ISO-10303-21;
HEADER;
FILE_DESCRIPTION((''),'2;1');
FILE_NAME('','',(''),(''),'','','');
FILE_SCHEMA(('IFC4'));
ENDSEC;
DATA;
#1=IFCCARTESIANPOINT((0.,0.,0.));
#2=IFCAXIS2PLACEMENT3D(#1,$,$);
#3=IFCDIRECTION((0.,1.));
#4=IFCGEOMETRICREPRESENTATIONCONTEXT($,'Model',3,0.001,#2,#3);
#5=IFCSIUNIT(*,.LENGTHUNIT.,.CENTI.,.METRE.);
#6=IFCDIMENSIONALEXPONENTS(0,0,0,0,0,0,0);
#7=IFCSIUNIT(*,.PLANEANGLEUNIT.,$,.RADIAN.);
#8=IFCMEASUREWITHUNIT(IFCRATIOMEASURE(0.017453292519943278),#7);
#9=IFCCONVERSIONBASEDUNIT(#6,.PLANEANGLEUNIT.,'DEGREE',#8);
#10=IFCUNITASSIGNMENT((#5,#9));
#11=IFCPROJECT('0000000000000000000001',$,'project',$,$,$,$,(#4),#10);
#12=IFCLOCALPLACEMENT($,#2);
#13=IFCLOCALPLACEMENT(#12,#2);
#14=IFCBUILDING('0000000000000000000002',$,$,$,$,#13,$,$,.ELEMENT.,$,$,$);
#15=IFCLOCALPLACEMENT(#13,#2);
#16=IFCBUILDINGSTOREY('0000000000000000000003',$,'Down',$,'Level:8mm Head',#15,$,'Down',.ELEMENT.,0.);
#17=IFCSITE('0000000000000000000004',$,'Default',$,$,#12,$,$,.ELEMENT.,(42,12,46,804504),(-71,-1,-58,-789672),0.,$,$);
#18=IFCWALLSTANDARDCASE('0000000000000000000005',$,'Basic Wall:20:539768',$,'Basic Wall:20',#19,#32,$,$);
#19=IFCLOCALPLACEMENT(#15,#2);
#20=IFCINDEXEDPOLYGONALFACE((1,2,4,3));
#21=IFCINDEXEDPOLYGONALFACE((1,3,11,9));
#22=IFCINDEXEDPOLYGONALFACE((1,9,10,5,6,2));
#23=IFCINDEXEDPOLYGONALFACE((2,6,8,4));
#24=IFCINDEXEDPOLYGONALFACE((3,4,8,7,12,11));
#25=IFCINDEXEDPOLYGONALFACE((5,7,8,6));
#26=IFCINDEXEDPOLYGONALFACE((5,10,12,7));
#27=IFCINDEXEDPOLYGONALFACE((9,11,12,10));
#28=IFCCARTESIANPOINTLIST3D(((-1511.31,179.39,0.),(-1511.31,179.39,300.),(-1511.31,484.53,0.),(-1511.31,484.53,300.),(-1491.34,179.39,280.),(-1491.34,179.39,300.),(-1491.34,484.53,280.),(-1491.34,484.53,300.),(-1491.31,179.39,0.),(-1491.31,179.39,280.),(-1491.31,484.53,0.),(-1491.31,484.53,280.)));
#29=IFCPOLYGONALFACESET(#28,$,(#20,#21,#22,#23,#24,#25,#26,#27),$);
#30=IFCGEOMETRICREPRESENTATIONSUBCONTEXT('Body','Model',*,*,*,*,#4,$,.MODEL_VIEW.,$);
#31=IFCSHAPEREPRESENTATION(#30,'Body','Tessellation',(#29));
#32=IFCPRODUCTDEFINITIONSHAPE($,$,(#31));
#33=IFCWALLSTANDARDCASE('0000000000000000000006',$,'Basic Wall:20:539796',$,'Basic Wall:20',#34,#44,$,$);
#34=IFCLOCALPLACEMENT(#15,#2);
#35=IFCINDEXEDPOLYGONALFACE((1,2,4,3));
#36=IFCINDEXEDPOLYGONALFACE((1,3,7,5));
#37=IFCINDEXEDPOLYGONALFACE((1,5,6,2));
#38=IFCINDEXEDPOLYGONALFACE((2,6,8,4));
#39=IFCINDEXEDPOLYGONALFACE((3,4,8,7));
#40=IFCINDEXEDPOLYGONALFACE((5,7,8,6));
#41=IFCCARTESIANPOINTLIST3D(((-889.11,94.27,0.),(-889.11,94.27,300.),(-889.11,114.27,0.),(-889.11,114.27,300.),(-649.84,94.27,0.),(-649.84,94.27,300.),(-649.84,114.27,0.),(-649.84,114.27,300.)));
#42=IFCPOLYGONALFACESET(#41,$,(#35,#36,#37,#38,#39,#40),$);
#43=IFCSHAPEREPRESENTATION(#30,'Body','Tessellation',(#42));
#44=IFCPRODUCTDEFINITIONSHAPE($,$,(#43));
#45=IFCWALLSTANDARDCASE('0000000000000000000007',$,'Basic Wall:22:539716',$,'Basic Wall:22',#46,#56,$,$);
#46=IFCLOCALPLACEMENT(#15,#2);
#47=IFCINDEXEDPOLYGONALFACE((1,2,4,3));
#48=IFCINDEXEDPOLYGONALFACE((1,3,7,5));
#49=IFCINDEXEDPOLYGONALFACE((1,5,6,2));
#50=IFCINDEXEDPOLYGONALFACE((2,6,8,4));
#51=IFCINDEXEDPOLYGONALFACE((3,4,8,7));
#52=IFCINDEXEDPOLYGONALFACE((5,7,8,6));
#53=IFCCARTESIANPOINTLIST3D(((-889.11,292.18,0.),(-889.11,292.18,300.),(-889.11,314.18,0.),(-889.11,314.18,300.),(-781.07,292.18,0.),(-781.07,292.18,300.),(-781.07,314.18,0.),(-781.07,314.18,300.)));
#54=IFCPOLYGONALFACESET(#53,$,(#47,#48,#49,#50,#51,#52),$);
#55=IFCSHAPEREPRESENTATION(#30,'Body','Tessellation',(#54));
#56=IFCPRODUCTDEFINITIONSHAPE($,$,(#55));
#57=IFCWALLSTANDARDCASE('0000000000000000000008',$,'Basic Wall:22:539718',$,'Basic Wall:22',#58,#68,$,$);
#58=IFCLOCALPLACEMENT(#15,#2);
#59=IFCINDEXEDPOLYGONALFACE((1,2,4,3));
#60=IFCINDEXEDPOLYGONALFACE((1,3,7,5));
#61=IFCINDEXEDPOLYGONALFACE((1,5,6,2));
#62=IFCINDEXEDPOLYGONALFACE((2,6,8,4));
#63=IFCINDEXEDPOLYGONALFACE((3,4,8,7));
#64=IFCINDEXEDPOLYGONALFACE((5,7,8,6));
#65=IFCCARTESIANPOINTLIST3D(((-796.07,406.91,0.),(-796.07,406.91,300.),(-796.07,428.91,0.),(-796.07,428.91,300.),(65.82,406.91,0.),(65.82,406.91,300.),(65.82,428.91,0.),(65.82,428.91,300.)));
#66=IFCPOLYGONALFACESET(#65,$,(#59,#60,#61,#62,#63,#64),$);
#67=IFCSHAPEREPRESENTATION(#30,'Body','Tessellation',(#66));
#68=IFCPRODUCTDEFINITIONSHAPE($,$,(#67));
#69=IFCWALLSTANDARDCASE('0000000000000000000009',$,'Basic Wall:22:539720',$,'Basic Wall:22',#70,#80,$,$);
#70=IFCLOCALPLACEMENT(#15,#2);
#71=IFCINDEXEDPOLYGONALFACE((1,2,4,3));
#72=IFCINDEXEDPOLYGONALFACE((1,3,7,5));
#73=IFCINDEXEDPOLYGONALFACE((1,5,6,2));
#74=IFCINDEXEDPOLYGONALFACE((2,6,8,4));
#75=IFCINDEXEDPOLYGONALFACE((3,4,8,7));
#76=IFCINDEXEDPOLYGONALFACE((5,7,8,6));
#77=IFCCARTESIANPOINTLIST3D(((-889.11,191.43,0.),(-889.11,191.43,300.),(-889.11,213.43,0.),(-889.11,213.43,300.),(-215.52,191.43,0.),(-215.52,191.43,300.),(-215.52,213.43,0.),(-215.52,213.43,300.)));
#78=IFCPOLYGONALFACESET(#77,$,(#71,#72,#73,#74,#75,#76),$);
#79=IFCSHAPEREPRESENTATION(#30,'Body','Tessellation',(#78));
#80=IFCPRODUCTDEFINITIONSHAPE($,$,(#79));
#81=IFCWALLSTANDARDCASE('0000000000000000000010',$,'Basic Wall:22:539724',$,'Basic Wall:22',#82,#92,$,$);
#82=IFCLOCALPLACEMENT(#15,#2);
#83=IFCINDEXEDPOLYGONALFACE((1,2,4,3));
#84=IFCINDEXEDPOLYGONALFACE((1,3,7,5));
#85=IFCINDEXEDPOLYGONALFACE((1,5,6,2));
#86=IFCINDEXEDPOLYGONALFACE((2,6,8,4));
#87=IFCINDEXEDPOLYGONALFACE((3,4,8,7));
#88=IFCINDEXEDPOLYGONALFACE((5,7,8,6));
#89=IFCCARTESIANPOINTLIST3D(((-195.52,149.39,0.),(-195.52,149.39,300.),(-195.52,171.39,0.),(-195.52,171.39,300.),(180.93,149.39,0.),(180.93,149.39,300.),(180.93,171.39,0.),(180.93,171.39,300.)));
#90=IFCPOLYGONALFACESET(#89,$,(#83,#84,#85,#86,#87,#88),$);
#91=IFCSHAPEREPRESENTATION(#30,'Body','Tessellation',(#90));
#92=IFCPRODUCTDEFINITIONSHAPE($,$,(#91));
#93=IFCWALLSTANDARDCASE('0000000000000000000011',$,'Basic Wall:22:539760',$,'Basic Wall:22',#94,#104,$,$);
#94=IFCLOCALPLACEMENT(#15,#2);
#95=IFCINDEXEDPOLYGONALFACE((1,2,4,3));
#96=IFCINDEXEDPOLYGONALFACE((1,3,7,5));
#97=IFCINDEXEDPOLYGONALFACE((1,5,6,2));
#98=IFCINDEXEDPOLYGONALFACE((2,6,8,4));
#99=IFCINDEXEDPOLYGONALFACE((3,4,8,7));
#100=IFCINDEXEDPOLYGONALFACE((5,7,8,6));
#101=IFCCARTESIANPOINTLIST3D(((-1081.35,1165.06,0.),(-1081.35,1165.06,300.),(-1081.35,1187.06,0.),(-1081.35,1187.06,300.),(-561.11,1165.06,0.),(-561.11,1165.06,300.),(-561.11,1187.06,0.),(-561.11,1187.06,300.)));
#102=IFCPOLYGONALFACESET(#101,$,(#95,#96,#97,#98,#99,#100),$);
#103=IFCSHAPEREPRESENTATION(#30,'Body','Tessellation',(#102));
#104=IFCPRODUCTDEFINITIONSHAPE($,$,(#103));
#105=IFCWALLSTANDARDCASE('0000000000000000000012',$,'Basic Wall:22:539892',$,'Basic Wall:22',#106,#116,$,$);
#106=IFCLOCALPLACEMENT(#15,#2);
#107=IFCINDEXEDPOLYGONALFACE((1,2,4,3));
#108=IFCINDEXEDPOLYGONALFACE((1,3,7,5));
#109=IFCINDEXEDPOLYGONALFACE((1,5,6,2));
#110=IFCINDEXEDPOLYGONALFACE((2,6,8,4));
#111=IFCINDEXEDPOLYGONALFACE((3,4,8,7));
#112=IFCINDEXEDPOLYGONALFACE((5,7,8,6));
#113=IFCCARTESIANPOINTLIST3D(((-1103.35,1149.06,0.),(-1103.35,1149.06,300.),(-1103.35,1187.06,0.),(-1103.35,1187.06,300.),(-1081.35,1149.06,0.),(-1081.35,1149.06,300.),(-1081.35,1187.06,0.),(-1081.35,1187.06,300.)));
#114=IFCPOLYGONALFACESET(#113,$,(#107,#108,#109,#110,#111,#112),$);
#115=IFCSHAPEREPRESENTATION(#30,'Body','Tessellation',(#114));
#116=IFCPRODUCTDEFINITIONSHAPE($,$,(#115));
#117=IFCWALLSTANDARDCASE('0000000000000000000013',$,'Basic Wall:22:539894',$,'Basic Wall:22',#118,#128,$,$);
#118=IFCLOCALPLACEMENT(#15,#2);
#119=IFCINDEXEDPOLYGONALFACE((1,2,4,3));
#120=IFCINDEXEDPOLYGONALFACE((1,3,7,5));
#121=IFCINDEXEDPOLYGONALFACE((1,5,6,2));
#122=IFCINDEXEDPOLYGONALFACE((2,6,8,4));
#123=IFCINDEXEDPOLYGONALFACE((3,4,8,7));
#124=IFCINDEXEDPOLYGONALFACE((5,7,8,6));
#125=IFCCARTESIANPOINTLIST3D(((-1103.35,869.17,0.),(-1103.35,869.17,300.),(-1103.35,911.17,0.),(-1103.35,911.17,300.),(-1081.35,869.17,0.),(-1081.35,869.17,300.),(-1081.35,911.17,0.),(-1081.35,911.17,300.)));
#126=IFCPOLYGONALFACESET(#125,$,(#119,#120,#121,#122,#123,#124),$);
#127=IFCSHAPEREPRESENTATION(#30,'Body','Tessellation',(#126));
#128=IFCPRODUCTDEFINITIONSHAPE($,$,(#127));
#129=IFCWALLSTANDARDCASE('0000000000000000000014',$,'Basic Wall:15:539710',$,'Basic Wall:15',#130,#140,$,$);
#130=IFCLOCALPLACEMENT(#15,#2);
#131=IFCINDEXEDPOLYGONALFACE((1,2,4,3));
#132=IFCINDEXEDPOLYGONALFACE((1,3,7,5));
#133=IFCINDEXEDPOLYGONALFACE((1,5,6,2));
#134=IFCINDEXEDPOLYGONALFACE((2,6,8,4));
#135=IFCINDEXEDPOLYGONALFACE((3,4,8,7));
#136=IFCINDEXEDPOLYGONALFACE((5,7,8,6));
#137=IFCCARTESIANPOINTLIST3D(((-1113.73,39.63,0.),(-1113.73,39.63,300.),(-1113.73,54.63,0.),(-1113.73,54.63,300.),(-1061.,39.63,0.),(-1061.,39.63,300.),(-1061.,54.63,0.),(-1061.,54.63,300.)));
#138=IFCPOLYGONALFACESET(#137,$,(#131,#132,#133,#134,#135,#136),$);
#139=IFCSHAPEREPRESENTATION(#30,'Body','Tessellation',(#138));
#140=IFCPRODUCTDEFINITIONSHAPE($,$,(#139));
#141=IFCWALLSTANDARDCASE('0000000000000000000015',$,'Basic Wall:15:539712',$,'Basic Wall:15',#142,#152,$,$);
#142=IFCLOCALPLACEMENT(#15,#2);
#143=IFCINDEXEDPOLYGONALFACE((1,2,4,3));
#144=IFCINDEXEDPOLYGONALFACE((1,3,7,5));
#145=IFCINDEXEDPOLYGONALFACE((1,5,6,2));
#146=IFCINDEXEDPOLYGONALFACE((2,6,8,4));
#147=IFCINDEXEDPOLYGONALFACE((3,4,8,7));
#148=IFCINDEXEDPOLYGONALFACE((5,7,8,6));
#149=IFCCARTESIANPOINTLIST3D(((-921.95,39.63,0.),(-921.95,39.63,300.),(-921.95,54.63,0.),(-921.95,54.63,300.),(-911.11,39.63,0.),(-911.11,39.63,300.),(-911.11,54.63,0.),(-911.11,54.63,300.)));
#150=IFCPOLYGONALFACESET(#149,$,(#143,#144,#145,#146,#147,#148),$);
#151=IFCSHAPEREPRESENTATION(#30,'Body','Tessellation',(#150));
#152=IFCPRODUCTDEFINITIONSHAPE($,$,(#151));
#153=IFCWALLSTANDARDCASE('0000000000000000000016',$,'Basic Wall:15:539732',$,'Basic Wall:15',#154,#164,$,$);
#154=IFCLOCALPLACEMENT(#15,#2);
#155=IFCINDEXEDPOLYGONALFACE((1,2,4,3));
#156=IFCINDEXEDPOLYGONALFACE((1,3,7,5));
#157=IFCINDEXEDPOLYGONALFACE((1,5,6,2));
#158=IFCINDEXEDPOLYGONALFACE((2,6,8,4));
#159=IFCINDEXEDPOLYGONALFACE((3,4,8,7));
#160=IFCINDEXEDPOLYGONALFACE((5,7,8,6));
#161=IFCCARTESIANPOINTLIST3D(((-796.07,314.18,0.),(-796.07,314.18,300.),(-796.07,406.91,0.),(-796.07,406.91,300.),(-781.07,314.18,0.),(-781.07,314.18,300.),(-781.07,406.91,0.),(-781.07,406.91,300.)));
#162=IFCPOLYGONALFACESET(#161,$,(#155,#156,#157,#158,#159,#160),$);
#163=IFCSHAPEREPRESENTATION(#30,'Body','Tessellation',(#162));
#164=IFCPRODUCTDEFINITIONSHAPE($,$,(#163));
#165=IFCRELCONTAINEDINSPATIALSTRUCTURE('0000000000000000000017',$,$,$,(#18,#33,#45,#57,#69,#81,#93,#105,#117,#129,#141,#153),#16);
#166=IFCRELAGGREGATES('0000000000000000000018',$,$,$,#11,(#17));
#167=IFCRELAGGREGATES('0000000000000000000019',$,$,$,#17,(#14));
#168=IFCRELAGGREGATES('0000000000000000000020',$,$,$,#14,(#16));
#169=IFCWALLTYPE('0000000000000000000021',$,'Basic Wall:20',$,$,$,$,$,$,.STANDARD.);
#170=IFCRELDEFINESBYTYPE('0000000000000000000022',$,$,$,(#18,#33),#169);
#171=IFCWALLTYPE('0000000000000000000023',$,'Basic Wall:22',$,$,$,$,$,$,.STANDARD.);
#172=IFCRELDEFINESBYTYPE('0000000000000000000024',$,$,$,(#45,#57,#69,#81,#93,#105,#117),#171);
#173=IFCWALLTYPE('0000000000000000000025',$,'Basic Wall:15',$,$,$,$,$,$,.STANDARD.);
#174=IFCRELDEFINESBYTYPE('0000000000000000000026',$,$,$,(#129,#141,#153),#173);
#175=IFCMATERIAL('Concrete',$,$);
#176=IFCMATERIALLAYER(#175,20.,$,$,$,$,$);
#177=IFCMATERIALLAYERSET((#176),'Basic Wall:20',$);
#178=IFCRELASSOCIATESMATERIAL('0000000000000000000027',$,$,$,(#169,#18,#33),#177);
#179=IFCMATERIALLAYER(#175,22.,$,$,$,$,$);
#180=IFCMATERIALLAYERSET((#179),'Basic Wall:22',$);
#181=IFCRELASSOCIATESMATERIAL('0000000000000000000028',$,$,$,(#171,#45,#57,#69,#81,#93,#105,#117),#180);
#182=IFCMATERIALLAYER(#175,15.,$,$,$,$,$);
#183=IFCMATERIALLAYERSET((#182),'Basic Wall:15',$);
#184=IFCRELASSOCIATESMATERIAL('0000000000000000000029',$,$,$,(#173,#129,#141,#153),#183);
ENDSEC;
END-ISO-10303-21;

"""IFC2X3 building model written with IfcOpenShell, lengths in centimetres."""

from ifc_helpers import new_model, entity, si_unit, converted_unit, direction, frame, frame_2d, origin, place, context, subcontext, project, spatial, polyline, rectangle, extrude, clip, bounded_halfspace, material, layer, layer_set, layer_usage, type_object, element, save


model = new_model("IFC2X3")

# Units and contexts
model_context = context("Model", 3, precision=0.001, world=origin(), true_north=direction((0.0, 1.0)))
body_context = subcontext(model_context, "Body", "Model", "MODEL_VIEW")
ifc_project = project(units=[si_unit("LENGTHUNIT", "METRE", prefix="CENTI"), converted_unit("PLANEANGLEUNIT", "DEGREE", entity("IfcRatioMeasure", 0.017453292519943278), si_unit("PLANEANGLEUNIT", "RADIAN"), dimensions=[0, 0, 0, 0, 0, 0, 0])], contexts=[model_context])

# Site, building, storey
site_placement = place(None, origin())
site = spatial("IfcSite", under=ifc_project, at=site_placement, Name="Default", CompositionType="ELEMENT", RefLatitude=(42, 12, 46, 804504), RefLongitude=(-71, -1, -58, -789672), RefElevation=0.0)
building_placement = place(site_placement, origin())
building = spatial("IfcBuilding", under=site, at=building_placement, CompositionType="ELEMENT")
storey_placement = place(building_placement, origin())
storey = spatial("IfcBuildingStorey", under=building, at=storey_placement, Name="Down", ObjectType="Level:8mm Head", LongName="Down", CompositionType="ELEMENT", Elevation=0.0)

# Walls
ifc_material = material(Name="Concrete")
ifc_layer_1 = layer(ifc_material, 20.0)
ifc_layer_set_1 = layer_set([ifc_layer_1], Name="Basic Wall:20")
wall_type_1 = type_object("IfcWallType", Name="Basic Wall:20", PredefinedType="STANDARD", material=ifc_layer_set_1)
ifc_layer_usage_1 = layer_usage(ifc_layer_set_1, "AXIS2", "POSITIVE", -10.0)
wall_1_placement = place(storey_placement, frame((-1501.31, 484.53, 0.0), z_axis=(0.0, 0.0, 1.0), x_axis=(0.0, -1.0, 0.0)))
element("IfcWallStandardCase", 1, at=wall_1_placement, inside=storey, type_object=wall_type_1, material=ifc_layer_usage_1, Name="Basic Wall:20:539768", ObjectType="Basic Wall:20", context=body_context, shape_type="Clipping", body=[
    clip(clip(extrude(rectangle(XDim=305.14, YDim=20.0, at=frame_2d((152.57, 0.0), x_axis=(-1.0, 0.0))), origin(), (0.0, 0.0, 1.0), 300.0), bounded_halfspace(frame((0.0, 9.97, 280.0), z_axis=(0.0, 0.0, -1.0), x_axis=(-1.0, 0.0, 0.0)), True, frame((0.0, 9.97, 280.0), z_axis=(0.0, 0.0, -1.0), x_axis=(-1.0, 0.0, 0.0)), polyline([(0.0, 0.0), (0.0, 0.03), (-305.14, 0.03), (-305.14, 0.0), (0.0, 0.0)]))), bounded_halfspace(frame((305.14, 9.97, 280.0), z_axis=(0.0, -1.0, 0.0), x_axis=(0.0, 0.0, 1.0)), True, frame((305.14, 9.97, 280.0), z_axis=(0.0, -1.0, 0.0), x_axis=(0.0, 0.0, 1.0)), polyline([(0.0, 0.0), (20.0, 0.0), (20.0, 305.14), (0.0, 305.14), (0.0, 0.0)]))),
])
ifc_layer_usage_2 = layer_usage(ifc_layer_set_1, "AXIS2", "NEGATIVE", 10.0)
wall_2_placement = place(storey_placement, frame((-889.11, 104.27, 0.0)))
element("IfcWallStandardCase", 2, at=wall_2_placement, inside=storey, type_object=wall_type_1, material=ifc_layer_usage_2, Name="Basic Wall:20:539796", ObjectType="Basic Wall:20", context=body_context, shape_type="SweptSolid", body=[
    extrude(rectangle(XDim=239.27, YDim=20.0, at=frame_2d((119.63, 0.0), x_axis=(-1.0, 0.0))), origin(), (0.0, 0.0, 1.0), 300.0),
])
ifc_layer_2 = layer(ifc_material, 22.0)
ifc_layer_set_2 = layer_set([ifc_layer_2], Name="Basic Wall:22")
ifc_layer_usage_3 = layer_usage(ifc_layer_set_2, "AXIS2", "NEGATIVE", 11.0)
wall_type_2 = type_object("IfcWallType", Name="Basic Wall:22", PredefinedType="STANDARD", material=ifc_layer_set_2)
wall_3_placement = place(storey_placement, frame((-889.11, 303.18, 0.0)))
element("IfcWallStandardCase", 3, at=wall_3_placement, inside=storey, type_object=wall_type_2, material=ifc_layer_usage_3, Name="Basic Wall:22:539716", ObjectType="Basic Wall:22", context=body_context, shape_type="SweptSolid", body=[
    extrude(rectangle(XDim=108.04, YDim=22.0, at=frame_2d((54.02, 0.0), x_axis=(-1.0, 0.0))), origin(), (0.0, 0.0, 1.0), 300.0),
])
ifc_layer_usage_4 = layer_usage(ifc_layer_set_2, "AXIS2", "POSITIVE", -11.0)
wall_4_placement = place(storey_placement, frame((-796.07, 417.91, 0.0)))
element("IfcWallStandardCase", 4, at=wall_4_placement, inside=storey, type_object=wall_type_2, material=ifc_layer_usage_4, Name="Basic Wall:22:539718", ObjectType="Basic Wall:22", context=body_context, shape_type="SweptSolid", body=[
    extrude(rectangle(XDim=861.89, YDim=22.0, at=frame_2d((430.94, 0.0), x_axis=(-1.0, 0.0))), origin(), (0.0, 0.0, 1.0), 300.0),
])
ifc_layer_usage_5 = layer_usage(ifc_layer_set_2, "AXIS2", "NEGATIVE", 11.0)
wall_5_placement = place(storey_placement, frame((-889.11, 202.43, 0.0)))
element("IfcWallStandardCase", 5, at=wall_5_placement, inside=storey, type_object=wall_type_2, material=ifc_layer_usage_5, Name="Basic Wall:22:539720", ObjectType="Basic Wall:22", context=body_context, shape_type="SweptSolid", body=[
    extrude(rectangle(XDim=673.59, YDim=22.0, at=frame_2d((336.79, 0.0), x_axis=(-1.0, 0.0))), origin(), (0.0, 0.0, 1.0), 300.0),
])
ifc_layer_usage_6 = layer_usage(ifc_layer_set_2, "AXIS2", "NEGATIVE", 11.0)
wall_6_placement = place(storey_placement, frame((-195.52, 160.39, 0.0)))
element("IfcWallStandardCase", 6, at=wall_6_placement, inside=storey, type_object=wall_type_2, material=ifc_layer_usage_6, Name="Basic Wall:22:539724", ObjectType="Basic Wall:22", context=body_context, shape_type="SweptSolid", body=[
    extrude(rectangle(XDim=376.45, YDim=22.0, at=frame_2d((188.23, 0.0), x_axis=(-1.0, 0.0))), origin(), (0.0, 0.0, 1.0), 300.0),
])
ifc_layer_usage_7 = layer_usage(ifc_layer_set_2, "AXIS2", "NEGATIVE", 11.0)
wall_7_placement = place(storey_placement, frame((-561.11, 1176.06, 0.0), z_axis=(0.0, 0.0, 1.0), x_axis=(-1.0, 0.0, 0.0)))
element("IfcWallStandardCase", 7, at=wall_7_placement, inside=storey, type_object=wall_type_2, material=ifc_layer_usage_7, Name="Basic Wall:22:539760", ObjectType="Basic Wall:22", context=body_context, shape_type="SweptSolid", body=[
    extrude(rectangle(XDim=520.24, YDim=22.0, at=frame_2d((260.12, 0.0), x_axis=(-1.0, 0.0))), origin(), (0.0, 0.0, 1.0), 300.0),
])
ifc_layer_usage_8 = layer_usage(ifc_layer_set_2, "AXIS2", "POSITIVE", -11.0)
wall_8_placement = place(storey_placement, frame((-1092.35, 1187.06, 0.0), z_axis=(0.0, 0.0, 1.0), x_axis=(0.0, -1.0, 0.0)))
element("IfcWallStandardCase", 8, at=wall_8_placement, inside=storey, type_object=wall_type_2, material=ifc_layer_usage_8, Name="Basic Wall:22:539892", ObjectType="Basic Wall:22", context=body_context, shape_type="SweptSolid", body=[
    extrude(rectangle(XDim=38.0, YDim=22.0, at=frame_2d((19.0, 0.0), x_axis=(-1.0, 0.0))), origin(), (0.0, 0.0, 1.0), 300.0),
])
ifc_layer_usage_9 = layer_usage(ifc_layer_set_2, "AXIS2", "POSITIVE", -11.0)
wall_9_placement = place(storey_placement, frame((-1092.35, 869.17, 0.0), z_axis=(0.0, 0.0, 1.0), x_axis=(0.0, 1.0, 0.0)))
element("IfcWallStandardCase", 9, at=wall_9_placement, inside=storey, type_object=wall_type_2, material=ifc_layer_usage_9, Name="Basic Wall:22:539894", ObjectType="Basic Wall:22", context=body_context, shape_type="SweptSolid", body=[
    extrude(rectangle(XDim=42.0, YDim=22.0, at=frame_2d((21.0, 0.0), x_axis=(-1.0, 0.0))), origin(), (0.0, 0.0, 1.0), 300.0),
])
ifc_layer_3 = layer(ifc_material, 15.0)
ifc_layer_set_3 = layer_set([ifc_layer_3], Name="Basic Wall:15")
ifc_layer_usage_10 = layer_usage(ifc_layer_set_3, "AXIS2", "NEGATIVE", 7.5)
wall_type_3 = type_object("IfcWallType", Name="Basic Wall:15", PredefinedType="STANDARD", material=ifc_layer_set_3)
wall_10_placement = place(storey_placement, frame((-1061.0, 47.13, 0.0), z_axis=(0.0, 0.0, 1.0), x_axis=(-1.0, 0.0, 0.0)))
element("IfcWallStandardCase", 10, at=wall_10_placement, inside=storey, type_object=wall_type_3, material=ifc_layer_usage_10, Name="Basic Wall:15:539710", ObjectType="Basic Wall:15", context=body_context, shape_type="SweptSolid", body=[
    extrude(rectangle(XDim=52.73, YDim=15.0, at=frame_2d((26.37, 0.0), x_axis=(-1.0, 0.0))), origin(), (0.0, 0.0, 1.0), 300.0),
])
ifc_layer_usage_11 = layer_usage(ifc_layer_set_3, "AXIS2", "POSITIVE", -7.5)
wall_11_placement = place(storey_placement, frame((-921.95, 47.13, 0.0)))
element("IfcWallStandardCase", 11, at=wall_11_placement, inside=storey, type_object=wall_type_3, material=ifc_layer_usage_11, Name="Basic Wall:15:539712", ObjectType="Basic Wall:15", context=body_context, shape_type="SweptSolid", body=[
    extrude(rectangle(XDim=10.85, YDim=15.0, at=frame_2d((5.42, 0.0), x_axis=(-1.0, 0.0))), origin(), (0.0, 0.0, 1.0), 300.0),
])
ifc_layer_usage_12 = layer_usage(ifc_layer_set_3, "AXIS2", "NEGATIVE", 7.5)
wall_12_placement = place(storey_placement, frame((-788.57, 406.91, 0.0), z_axis=(0.0, 0.0, 1.0), x_axis=(0.0, -1.0, 0.0)))
element("IfcWallStandardCase", 12, at=wall_12_placement, inside=storey, type_object=wall_type_3, material=ifc_layer_usage_12, Name="Basic Wall:15:539732", ObjectType="Basic Wall:15", context=body_context, shape_type="SweptSolid", body=[
    extrude(rectangle(XDim=92.73, YDim=15.0, at=frame_2d((46.36, 0.0), x_axis=(-1.0, 0.0))), origin(), (0.0, 0.0, 1.0), 300.0),
])

save(model, "model.ifc")
